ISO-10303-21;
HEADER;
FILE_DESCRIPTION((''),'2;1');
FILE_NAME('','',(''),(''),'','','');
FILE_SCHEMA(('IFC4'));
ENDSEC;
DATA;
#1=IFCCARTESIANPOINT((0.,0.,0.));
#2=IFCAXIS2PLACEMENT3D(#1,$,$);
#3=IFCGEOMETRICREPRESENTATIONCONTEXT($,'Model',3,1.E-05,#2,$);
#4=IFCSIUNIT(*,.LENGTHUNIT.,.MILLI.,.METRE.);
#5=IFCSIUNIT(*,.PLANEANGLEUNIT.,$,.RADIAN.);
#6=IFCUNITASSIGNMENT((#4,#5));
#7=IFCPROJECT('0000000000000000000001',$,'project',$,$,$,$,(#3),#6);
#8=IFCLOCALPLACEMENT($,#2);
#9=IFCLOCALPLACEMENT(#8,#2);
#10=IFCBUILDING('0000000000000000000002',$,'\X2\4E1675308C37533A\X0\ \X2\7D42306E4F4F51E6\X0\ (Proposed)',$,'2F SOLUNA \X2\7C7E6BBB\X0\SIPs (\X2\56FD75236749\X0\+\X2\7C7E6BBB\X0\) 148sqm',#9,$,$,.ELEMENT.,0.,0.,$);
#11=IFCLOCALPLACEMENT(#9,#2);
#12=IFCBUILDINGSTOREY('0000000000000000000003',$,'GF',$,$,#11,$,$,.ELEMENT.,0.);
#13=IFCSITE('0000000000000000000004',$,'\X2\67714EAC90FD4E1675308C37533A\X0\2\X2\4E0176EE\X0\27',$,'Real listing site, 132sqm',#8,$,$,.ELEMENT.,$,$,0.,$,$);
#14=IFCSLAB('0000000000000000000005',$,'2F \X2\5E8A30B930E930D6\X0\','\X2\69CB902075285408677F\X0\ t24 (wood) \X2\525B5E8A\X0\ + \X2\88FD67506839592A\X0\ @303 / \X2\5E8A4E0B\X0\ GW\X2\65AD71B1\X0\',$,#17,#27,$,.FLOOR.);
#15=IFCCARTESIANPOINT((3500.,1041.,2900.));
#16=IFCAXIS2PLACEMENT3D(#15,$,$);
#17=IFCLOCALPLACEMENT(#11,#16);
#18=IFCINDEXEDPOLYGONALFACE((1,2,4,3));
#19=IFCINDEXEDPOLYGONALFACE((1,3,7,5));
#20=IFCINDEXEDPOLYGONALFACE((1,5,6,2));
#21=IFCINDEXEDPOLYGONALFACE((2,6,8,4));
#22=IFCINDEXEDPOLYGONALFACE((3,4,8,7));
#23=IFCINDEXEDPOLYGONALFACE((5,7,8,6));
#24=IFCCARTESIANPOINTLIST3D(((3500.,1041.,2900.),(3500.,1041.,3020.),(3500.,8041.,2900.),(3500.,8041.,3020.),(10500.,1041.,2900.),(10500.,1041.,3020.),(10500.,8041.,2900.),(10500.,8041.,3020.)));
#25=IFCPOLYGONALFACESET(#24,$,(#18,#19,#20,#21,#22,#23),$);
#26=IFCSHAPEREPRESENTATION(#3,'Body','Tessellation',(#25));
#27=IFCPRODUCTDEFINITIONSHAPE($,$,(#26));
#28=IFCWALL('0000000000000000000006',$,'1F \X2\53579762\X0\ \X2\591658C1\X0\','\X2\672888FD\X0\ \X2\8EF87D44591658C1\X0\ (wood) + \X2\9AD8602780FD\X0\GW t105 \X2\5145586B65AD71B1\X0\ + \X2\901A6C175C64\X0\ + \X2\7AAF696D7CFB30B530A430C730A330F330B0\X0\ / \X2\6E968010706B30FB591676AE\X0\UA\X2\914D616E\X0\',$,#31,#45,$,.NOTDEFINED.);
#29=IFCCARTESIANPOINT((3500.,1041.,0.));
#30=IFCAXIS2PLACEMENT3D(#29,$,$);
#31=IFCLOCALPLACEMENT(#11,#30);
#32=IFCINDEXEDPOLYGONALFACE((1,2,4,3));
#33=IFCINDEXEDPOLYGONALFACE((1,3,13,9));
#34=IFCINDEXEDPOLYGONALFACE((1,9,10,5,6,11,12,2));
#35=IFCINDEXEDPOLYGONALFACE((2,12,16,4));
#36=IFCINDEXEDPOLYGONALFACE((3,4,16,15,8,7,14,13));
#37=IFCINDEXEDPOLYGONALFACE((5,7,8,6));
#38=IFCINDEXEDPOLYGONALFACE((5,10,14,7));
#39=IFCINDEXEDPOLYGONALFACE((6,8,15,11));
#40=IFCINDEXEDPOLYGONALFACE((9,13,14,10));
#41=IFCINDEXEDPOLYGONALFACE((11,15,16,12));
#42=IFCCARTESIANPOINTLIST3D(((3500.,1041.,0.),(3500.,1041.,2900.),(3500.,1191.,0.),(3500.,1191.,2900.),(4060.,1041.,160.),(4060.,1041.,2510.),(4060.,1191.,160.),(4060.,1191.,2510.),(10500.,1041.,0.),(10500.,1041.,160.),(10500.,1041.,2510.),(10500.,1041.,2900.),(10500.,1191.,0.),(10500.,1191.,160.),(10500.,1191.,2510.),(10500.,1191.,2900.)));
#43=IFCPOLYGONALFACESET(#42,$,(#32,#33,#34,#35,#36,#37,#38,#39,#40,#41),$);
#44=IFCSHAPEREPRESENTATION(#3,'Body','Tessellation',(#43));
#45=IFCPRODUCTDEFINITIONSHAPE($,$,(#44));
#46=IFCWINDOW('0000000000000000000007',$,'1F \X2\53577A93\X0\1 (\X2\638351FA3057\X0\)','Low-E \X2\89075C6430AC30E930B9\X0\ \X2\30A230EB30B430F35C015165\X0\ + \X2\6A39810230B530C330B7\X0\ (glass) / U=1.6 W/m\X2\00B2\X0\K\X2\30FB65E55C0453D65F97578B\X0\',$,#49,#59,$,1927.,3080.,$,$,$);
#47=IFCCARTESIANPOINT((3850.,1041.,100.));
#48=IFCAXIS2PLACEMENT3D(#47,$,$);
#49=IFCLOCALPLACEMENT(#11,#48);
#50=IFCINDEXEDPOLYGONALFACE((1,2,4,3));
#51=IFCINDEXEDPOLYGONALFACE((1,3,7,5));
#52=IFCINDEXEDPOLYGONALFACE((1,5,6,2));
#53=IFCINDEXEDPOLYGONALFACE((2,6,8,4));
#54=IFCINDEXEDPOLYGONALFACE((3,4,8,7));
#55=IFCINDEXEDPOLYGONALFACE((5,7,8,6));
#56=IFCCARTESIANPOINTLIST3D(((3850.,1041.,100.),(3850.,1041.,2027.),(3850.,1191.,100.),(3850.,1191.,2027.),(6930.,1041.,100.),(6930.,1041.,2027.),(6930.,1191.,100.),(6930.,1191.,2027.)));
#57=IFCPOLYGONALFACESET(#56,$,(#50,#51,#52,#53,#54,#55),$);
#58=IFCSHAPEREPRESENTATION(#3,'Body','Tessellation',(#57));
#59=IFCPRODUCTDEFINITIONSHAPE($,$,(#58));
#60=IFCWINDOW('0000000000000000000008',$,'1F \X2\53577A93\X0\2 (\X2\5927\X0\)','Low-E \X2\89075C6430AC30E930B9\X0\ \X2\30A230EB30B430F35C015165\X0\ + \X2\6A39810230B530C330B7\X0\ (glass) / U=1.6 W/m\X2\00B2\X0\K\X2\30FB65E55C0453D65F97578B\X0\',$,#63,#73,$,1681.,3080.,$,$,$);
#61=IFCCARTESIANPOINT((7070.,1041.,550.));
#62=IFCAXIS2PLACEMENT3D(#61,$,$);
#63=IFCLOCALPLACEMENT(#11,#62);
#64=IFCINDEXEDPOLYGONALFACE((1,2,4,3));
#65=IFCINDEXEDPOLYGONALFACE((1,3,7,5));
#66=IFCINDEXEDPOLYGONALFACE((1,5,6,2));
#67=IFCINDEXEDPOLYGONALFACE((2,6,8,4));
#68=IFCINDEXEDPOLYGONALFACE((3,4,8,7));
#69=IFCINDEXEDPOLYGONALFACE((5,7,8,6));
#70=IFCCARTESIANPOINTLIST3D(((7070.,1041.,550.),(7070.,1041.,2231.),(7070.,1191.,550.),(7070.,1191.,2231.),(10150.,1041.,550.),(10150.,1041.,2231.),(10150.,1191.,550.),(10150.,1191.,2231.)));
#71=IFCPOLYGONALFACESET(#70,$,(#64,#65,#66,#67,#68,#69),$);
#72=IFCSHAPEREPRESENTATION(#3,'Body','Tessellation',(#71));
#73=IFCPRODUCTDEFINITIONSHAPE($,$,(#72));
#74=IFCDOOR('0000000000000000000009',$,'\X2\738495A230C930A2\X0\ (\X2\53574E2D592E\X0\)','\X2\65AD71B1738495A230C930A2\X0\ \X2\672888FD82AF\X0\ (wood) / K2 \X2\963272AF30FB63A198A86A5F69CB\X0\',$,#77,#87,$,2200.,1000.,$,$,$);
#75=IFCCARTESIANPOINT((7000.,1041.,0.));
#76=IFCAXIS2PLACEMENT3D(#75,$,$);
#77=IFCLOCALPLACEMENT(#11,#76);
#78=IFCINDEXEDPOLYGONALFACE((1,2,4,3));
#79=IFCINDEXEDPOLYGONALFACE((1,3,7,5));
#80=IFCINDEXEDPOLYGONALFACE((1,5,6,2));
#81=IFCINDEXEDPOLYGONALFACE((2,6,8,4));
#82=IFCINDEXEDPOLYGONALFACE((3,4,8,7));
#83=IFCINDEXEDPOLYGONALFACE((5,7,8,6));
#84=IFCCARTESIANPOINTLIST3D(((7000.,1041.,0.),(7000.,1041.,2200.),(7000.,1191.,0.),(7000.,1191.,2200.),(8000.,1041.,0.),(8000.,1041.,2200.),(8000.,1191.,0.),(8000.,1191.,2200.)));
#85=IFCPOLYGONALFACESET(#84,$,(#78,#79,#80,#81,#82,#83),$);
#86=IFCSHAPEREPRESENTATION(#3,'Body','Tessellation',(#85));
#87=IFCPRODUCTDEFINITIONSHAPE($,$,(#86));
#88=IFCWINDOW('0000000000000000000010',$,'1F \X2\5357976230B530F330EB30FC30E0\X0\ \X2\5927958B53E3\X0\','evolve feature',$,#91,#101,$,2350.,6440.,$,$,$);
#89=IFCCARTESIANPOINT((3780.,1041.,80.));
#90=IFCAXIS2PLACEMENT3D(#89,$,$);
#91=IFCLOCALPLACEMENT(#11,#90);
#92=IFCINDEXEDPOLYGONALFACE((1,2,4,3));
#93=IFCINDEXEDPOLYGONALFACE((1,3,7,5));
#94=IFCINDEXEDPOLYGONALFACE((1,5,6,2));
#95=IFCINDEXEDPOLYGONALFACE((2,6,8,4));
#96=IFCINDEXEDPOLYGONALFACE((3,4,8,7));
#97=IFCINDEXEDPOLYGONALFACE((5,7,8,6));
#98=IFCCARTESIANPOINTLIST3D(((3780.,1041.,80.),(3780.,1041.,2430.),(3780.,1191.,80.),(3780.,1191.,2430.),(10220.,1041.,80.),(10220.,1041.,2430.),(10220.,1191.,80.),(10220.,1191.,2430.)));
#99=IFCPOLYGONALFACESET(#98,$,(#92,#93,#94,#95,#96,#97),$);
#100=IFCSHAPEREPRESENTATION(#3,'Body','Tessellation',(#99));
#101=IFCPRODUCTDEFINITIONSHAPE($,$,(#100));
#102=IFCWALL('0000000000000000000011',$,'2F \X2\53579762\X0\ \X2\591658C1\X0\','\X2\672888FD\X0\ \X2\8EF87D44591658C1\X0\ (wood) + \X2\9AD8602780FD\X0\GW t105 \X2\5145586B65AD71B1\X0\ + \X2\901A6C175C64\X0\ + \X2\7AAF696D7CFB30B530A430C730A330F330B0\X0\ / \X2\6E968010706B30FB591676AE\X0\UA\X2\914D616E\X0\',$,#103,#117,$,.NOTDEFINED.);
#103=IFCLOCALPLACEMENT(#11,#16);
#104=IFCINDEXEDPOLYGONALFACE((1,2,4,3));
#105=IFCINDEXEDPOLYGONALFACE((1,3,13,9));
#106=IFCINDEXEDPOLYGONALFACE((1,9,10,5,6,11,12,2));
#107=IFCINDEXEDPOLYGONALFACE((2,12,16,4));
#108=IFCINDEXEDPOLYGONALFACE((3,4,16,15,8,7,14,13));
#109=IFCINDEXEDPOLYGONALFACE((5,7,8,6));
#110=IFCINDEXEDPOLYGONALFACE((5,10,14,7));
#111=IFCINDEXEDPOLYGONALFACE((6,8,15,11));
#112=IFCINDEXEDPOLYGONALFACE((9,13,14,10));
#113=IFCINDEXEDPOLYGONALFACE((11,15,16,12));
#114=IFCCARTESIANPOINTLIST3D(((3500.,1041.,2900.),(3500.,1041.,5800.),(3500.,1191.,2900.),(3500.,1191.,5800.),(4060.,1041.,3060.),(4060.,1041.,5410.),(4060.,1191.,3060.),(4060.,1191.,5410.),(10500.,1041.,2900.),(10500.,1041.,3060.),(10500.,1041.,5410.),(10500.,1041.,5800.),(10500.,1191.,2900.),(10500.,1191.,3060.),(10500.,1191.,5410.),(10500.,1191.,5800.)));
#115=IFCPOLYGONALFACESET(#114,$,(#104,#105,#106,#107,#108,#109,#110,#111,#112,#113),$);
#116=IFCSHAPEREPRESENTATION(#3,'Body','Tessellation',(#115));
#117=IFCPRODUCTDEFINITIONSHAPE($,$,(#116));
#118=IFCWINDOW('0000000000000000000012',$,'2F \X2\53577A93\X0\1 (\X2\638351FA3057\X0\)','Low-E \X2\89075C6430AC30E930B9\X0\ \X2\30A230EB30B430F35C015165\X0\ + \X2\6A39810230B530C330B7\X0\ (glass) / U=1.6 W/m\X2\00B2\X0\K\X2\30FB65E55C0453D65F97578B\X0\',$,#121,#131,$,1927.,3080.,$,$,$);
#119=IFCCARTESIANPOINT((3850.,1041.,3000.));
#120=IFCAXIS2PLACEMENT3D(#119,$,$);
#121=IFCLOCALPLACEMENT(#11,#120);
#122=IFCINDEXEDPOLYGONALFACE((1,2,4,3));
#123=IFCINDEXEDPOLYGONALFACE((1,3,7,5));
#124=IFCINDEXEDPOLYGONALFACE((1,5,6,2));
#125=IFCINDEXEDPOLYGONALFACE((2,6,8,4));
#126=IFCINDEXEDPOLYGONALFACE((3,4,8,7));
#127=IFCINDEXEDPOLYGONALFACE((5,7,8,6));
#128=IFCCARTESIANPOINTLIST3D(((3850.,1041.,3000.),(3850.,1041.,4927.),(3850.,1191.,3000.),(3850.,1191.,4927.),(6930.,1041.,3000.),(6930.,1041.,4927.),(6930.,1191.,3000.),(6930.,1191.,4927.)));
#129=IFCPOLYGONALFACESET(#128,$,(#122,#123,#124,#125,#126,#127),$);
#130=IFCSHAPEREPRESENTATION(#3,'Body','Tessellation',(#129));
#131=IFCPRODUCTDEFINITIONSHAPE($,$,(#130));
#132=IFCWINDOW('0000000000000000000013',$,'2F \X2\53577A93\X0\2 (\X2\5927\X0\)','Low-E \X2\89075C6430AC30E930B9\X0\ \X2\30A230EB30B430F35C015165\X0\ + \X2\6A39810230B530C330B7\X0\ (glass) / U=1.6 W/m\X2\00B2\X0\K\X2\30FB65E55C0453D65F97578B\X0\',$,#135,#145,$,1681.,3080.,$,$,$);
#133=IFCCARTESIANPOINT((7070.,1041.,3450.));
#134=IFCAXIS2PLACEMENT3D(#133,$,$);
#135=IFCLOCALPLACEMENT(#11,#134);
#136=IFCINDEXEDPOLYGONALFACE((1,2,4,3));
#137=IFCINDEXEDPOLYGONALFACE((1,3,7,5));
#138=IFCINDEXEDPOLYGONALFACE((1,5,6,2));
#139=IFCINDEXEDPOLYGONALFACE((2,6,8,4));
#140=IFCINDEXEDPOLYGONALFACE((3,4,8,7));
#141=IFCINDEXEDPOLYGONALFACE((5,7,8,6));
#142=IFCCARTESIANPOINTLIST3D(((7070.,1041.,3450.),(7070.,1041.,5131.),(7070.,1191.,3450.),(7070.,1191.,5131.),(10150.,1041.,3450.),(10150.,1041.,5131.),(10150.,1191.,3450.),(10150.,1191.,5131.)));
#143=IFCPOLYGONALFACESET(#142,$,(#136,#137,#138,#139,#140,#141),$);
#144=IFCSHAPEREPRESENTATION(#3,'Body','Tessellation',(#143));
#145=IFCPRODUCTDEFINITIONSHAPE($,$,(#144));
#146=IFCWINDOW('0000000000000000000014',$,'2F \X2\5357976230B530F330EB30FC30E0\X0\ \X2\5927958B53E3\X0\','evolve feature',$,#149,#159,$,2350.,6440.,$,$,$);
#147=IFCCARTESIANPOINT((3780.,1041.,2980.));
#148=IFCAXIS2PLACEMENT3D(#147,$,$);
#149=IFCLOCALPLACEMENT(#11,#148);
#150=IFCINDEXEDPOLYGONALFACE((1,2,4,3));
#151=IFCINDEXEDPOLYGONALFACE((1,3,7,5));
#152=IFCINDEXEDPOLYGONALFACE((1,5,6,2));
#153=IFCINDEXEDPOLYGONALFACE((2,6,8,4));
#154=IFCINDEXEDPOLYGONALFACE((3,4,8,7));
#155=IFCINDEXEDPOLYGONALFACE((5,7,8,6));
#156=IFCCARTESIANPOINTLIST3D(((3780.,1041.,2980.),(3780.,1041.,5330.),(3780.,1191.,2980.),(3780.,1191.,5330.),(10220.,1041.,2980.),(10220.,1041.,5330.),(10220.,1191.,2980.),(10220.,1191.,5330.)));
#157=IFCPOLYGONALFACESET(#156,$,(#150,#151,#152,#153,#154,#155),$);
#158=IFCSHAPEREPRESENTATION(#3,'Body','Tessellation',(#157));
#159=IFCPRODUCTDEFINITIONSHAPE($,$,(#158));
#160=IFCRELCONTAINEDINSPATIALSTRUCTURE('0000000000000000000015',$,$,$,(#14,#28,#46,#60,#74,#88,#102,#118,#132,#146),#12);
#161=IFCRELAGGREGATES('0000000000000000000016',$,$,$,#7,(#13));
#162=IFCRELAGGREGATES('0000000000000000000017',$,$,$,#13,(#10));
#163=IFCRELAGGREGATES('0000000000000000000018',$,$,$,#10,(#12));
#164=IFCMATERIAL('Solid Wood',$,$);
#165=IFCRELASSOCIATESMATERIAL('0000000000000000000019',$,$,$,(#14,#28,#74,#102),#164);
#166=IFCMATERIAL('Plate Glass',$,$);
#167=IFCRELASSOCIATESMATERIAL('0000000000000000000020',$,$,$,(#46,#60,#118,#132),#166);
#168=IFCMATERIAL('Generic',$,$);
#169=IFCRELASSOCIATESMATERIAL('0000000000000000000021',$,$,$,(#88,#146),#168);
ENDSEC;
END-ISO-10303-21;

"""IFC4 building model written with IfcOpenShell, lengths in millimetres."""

from ifc_helpers import new_model, si_unit, frame, frame_2d, origin, place, context, project, spatial, rectangle, extrude, material, element, fill, save


model = new_model("IFC4")

# Units and contexts
model_context = context("Model", 3, precision=1e-05, world=origin())
ifc_project = project(units=[si_unit("LENGTHUNIT", "METRE", prefix="MILLI"), si_unit("PLANEANGLEUNIT", "RADIAN")], contexts=[model_context])

# Site, building, storey
site_placement = place(None, origin())
site = spatial("IfcSite", under=ifc_project, at=site_placement, Name="東京都世田谷区2丁目27", ObjectType="Real listing site, 132sqm", CompositionType="ELEMENT", RefElevation=0.0)
building_placement = place(site_placement, origin())
building = spatial("IfcBuilding", under=site, at=building_placement, Name="世田谷区 終の住処 (Proposed)", ObjectType="2F SOLUNA 籾殻SIPs (国産杉+籾殻) 148sqm", CompositionType="ELEMENT", ElevationOfRefHeight=0.0, ElevationOfTerrain=0.0)
storey_placement = place(building_placement, origin())
storey = spatial("IfcBuildingStorey", under=building, at=storey_placement, Name="GF", CompositionType="ELEMENT", Elevation=0.0)

# Slab
ifc_material_1 = material(Name="Solid Wood")
slab_1_placement = place(storey_placement, frame((3500.0, 1041.0, 2900.0)))
element("IfcSlab", 1, at=slab_1_placement, inside=storey, material=ifc_material_1, Name="2F 床スラブ", Description="構造用合板 t24 (wood) 剛床 + 製材根太 @303 / 床下 GW断熱", PredefinedType="FLOOR", context=model_context, shape_type="SweptSolid", body=[
    extrude(rectangle(XDim=7000.0, YDim=7000.0, at=frame_2d((3500.0, 3500.0))), frame((3500.0, 1041.0, 2900.0)), (0.0, 0.0, 1.0), 120.0),
])
ifc_material_2 = material(Name="Generic")

# Wall, openings, windows, door
wall_1_placement = place(storey_placement, frame((3500.0, 1041.0, 0.0)))
wall_1 = element("IfcWall", 2, at=wall_1_placement, inside=storey, material=ifc_material_1, Name="1F 南面 外壁", Description="木製 軸組外壁 (wood) + 高性能GW t105 充填断熱 + 通気層 + 窯業系サイディング / 準耐火・外皮UA配慮", PredefinedType="NOTDEFINED", context=model_context, shape_type="SweptSolid", body=[
    extrude(rectangle(XDim=7000.0, YDim=150.0, at=frame_2d((3500.0, 75.0))), frame((3500.0, 1041.0, 0.0)), (0.0, 0.0, 1.0), 2900.0),
])
opening_1_placement = place(storey_placement, frame((3850.0, 1041.0, 100.0)))
opening_1 = element("IfcOpeningElement", 3, at=opening_1_placement, cuts=wall_1, PredefinedType="NOTDEFINED", context=model_context, shape_type="SweptSolid", body=[
    extrude(rectangle(XDim=3080.0, YDim=150.0, at=frame_2d((1540.0, 75.0))), frame((3850.0, 1041.0, 100.0)), (0.0, 0.0, 1.0), 1927.0),
])
opening_2_placement = place(storey_placement, frame((7070.0, 1041.0, 550.0)))
opening_2 = element("IfcOpeningElement", 4, at=opening_2_placement, cuts=wall_1, PredefinedType="NOTDEFINED", context=model_context, shape_type="SweptSolid", body=[
    extrude(rectangle(XDim=3080.0, YDim=150.0, at=frame_2d((1540.0, 75.0))), frame((7070.0, 1041.0, 550.0)), (0.0, 0.0, 1.0), 1681.0),
])
opening_3_placement = place(storey_placement, frame((7000.0, 1041.0, 0.0)))
opening_3 = element("IfcOpeningElement", 5, at=opening_3_placement, cuts=wall_1, PredefinedType="NOTDEFINED", context=model_context, shape_type="SweptSolid", body=[
    extrude(rectangle(XDim=1000.0, YDim=150.0, at=frame_2d((500.0, 75.0))), frame((7000.0, 1041.0, 0.0)), (0.0, 0.0, 1.0), 2200.0),
])
opening_4_placement = place(storey_placement, frame((3780.0, 1041.0, 80.0)))
opening_4 = element("IfcOpeningElement", 6, at=opening_4_placement, cuts=wall_1, PredefinedType="NOTDEFINED", context=model_context, shape_type="SweptSolid", body=[
    extrude(rectangle(XDim=6440.0, YDim=150.0, at=frame_2d((3220.0, 75.0))), frame((3780.0, 1041.0, 80.0)), (0.0, 0.0, 1.0), 2350.0),
])
ifc_material_3 = material(Name="Plate Glass")
window_1_placement = place(storey_placement, frame((3850.0, 1041.0, 100.0)))
window_1 = element("IfcWindow", 7, at=window_1_placement, inside=storey, material=ifc_material_3, Name="1F 南窓1 (掃出し)", Description="Low-E 複層ガラス アルゴン封入 + 樹脂サッシ (glass) / U=1.6 W/m²K・日射取得型", OverallHeight=1927.0, OverallWidth=3080.0, context=model_context, shape_type="SweptSolid", body=[
    extrude(rectangle(XDim=3080.0, YDim=150.0, at=frame_2d((1540.0, 75.0))), frame((3850.0, 1041.0, 100.0)), (0.0, 0.0, 1.0), 1927.0),
])
fill(opening_1, window_1)
window_2_placement = place(storey_placement, frame((7070.0, 1041.0, 550.0)))
window_2 = element("IfcWindow", 8, at=window_2_placement, inside=storey, material=ifc_material_3, Name="1F 南窓2 (大)", Description="Low-E 複層ガラス アルゴン封入 + 樹脂サッシ (glass) / U=1.6 W/m²K・日射取得型", OverallHeight=1681.0, OverallWidth=3080.0, context=model_context, shape_type="SweptSolid", body=[
    extrude(rectangle(XDim=3080.0, YDim=150.0, at=frame_2d((1540.0, 75.0))), frame((7070.0, 1041.0, 550.0)), (0.0, 0.0, 1.0), 1681.0),
])
fill(opening_2, window_2)
door_placement = place(storey_placement, frame((7000.0, 1041.0, 0.0)))
door = element("IfcDoor", 9, at=door_placement, inside=storey, material=ifc_material_1, Name="玄関ドア (南中央)", Description="断熱玄関ドア 木製芯 (wood) / K2 防犯・採風機構", OverallHeight=2200.0, OverallWidth=1000.0, context=model_context, shape_type="SweptSolid", body=[
    extrude(rectangle(XDim=1000.0, YDim=150.0, at=frame_2d((500.0, 75.0))), frame((7000.0, 1041.0, 0.0)), (0.0, 0.0, 1.0), 2200.0),
])
fill(opening_3, door)
window_3_placement = place(storey_placement, frame((3780.0, 1041.0, 80.0)))
window_3 = element("IfcWindow", 10, at=window_3_placement, inside=storey, material=ifc_material_2, Name="1F 南面サンルーム 大開口", Description="evolve feature", OverallHeight=2350.0, OverallWidth=6440.0, context=model_context, shape_type="SweptSolid", body=[
    extrude(rectangle(XDim=6440.0, YDim=150.0, at=frame_2d((3220.0, 75.0))), frame((3780.0, 1041.0, 80.0)), (0.0, 0.0, 1.0), 2350.0),
])
fill(opening_4, window_3)

# Wall, openings, windows
wall_2_placement = place(storey_placement, frame((3500.0, 1041.0, 2900.0)))
wall_2 = element("IfcWall", 11, at=wall_2_placement, inside=storey, material=ifc_material_1, Name="2F 南面 外壁", Description="木製 軸組外壁 (wood) + 高性能GW t105 充填断熱 + 通気層 + 窯業系サイディング / 準耐火・外皮UA配慮", PredefinedType="NOTDEFINED", context=model_context, shape_type="SweptSolid", body=[
    extrude(rectangle(XDim=7000.0, YDim=150.0, at=frame_2d((3500.0, 75.0))), frame((3500.0, 1041.0, 2900.0)), (0.0, 0.0, 1.0), 2900.0),
])
opening_5_placement = place(storey_placement, frame((3850.0, 1041.0, 3000.0)))
opening_5 = element("IfcOpeningElement", 12, at=opening_5_placement, cuts=wall_2, PredefinedType="NOTDEFINED", context=model_context, shape_type="SweptSolid", body=[
    extrude(rectangle(XDim=3080.0, YDim=150.0, at=frame_2d((1540.0, 75.0))), frame((3850.0, 1041.0, 3000.0)), (0.0, 0.0, 1.0), 1927.0),
])
opening_6_placement = place(storey_placement, frame((7070.0, 1041.0, 3450.0)))
opening_6 = element("IfcOpeningElement", 13, at=opening_6_placement, cuts=wall_2, PredefinedType="NOTDEFINED", context=model_context, shape_type="SweptSolid", body=[
    extrude(rectangle(XDim=3080.0, YDim=150.0, at=frame_2d((1540.0, 75.0))), frame((7070.0, 1041.0, 3450.0)), (0.0, 0.0, 1.0), 1681.0),
])
opening_7_placement = place(storey_placement, frame((3780.0, 1041.0, 2980.0)))
opening_7 = element("IfcOpeningElement", 14, at=opening_7_placement, cuts=wall_2, PredefinedType="NOTDEFINED", context=model_context, shape_type="SweptSolid", body=[
    extrude(rectangle(XDim=6440.0, YDim=150.0, at=frame_2d((3220.0, 75.0))), frame((3780.0, 1041.0, 2980.0)), (0.0, 0.0, 1.0), 2350.0),
])
window_4_placement = place(storey_placement, frame((3850.0, 1041.0, 3000.0)))
window_4 = element("IfcWindow", 15, at=window_4_placement, inside=storey, material=ifc_material_3, Name="2F 南窓1 (掃出し)", Description="Low-E 複層ガラス アルゴン封入 + 樹脂サッシ (glass) / U=1.6 W/m²K・日射取得型", OverallHeight=1927.0, OverallWidth=3080.0, context=model_context, shape_type="SweptSolid", body=[
    extrude(rectangle(XDim=3080.0, YDim=150.0, at=frame_2d((1540.0, 75.0))), frame((3850.0, 1041.0, 3000.0)), (0.0, 0.0, 1.0), 1927.0),
])
fill(opening_5, window_4)
window_5_placement = place(storey_placement, frame((7070.0, 1041.0, 3450.0)))
window_5 = element("IfcWindow", 16, at=window_5_placement, inside=storey, material=ifc_material_3, Name="2F 南窓2 (大)", Description="Low-E 複層ガラス アルゴン封入 + 樹脂サッシ (glass) / U=1.6 W/m²K・日射取得型", OverallHeight=1681.0, OverallWidth=3080.0, context=model_context, shape_type="SweptSolid", body=[
    extrude(rectangle(XDim=3080.0, YDim=150.0, at=frame_2d((1540.0, 75.0))), frame((7070.0, 1041.0, 3450.0)), (0.0, 0.0, 1.0), 1681.0),
])
fill(opening_6, window_5)
window_6_placement = place(storey_placement, frame((3780.0, 1041.0, 2980.0)))
window_6 = element("IfcWindow", 17, at=window_6_placement, inside=storey, material=ifc_material_2, Name="2F 南面サンルーム 大開口", Description="evolve feature", OverallHeight=2350.0, OverallWidth=6440.0, context=model_context, shape_type="SweptSolid", body=[
    extrude(rectangle(XDim=6440.0, YDim=150.0, at=frame_2d((3220.0, 75.0))), frame((3780.0, 1041.0, 2980.0)), (0.0, 0.0, 1.0), 2350.0),
])
fill(opening_7, window_6)

save(model, "model.ifc")
